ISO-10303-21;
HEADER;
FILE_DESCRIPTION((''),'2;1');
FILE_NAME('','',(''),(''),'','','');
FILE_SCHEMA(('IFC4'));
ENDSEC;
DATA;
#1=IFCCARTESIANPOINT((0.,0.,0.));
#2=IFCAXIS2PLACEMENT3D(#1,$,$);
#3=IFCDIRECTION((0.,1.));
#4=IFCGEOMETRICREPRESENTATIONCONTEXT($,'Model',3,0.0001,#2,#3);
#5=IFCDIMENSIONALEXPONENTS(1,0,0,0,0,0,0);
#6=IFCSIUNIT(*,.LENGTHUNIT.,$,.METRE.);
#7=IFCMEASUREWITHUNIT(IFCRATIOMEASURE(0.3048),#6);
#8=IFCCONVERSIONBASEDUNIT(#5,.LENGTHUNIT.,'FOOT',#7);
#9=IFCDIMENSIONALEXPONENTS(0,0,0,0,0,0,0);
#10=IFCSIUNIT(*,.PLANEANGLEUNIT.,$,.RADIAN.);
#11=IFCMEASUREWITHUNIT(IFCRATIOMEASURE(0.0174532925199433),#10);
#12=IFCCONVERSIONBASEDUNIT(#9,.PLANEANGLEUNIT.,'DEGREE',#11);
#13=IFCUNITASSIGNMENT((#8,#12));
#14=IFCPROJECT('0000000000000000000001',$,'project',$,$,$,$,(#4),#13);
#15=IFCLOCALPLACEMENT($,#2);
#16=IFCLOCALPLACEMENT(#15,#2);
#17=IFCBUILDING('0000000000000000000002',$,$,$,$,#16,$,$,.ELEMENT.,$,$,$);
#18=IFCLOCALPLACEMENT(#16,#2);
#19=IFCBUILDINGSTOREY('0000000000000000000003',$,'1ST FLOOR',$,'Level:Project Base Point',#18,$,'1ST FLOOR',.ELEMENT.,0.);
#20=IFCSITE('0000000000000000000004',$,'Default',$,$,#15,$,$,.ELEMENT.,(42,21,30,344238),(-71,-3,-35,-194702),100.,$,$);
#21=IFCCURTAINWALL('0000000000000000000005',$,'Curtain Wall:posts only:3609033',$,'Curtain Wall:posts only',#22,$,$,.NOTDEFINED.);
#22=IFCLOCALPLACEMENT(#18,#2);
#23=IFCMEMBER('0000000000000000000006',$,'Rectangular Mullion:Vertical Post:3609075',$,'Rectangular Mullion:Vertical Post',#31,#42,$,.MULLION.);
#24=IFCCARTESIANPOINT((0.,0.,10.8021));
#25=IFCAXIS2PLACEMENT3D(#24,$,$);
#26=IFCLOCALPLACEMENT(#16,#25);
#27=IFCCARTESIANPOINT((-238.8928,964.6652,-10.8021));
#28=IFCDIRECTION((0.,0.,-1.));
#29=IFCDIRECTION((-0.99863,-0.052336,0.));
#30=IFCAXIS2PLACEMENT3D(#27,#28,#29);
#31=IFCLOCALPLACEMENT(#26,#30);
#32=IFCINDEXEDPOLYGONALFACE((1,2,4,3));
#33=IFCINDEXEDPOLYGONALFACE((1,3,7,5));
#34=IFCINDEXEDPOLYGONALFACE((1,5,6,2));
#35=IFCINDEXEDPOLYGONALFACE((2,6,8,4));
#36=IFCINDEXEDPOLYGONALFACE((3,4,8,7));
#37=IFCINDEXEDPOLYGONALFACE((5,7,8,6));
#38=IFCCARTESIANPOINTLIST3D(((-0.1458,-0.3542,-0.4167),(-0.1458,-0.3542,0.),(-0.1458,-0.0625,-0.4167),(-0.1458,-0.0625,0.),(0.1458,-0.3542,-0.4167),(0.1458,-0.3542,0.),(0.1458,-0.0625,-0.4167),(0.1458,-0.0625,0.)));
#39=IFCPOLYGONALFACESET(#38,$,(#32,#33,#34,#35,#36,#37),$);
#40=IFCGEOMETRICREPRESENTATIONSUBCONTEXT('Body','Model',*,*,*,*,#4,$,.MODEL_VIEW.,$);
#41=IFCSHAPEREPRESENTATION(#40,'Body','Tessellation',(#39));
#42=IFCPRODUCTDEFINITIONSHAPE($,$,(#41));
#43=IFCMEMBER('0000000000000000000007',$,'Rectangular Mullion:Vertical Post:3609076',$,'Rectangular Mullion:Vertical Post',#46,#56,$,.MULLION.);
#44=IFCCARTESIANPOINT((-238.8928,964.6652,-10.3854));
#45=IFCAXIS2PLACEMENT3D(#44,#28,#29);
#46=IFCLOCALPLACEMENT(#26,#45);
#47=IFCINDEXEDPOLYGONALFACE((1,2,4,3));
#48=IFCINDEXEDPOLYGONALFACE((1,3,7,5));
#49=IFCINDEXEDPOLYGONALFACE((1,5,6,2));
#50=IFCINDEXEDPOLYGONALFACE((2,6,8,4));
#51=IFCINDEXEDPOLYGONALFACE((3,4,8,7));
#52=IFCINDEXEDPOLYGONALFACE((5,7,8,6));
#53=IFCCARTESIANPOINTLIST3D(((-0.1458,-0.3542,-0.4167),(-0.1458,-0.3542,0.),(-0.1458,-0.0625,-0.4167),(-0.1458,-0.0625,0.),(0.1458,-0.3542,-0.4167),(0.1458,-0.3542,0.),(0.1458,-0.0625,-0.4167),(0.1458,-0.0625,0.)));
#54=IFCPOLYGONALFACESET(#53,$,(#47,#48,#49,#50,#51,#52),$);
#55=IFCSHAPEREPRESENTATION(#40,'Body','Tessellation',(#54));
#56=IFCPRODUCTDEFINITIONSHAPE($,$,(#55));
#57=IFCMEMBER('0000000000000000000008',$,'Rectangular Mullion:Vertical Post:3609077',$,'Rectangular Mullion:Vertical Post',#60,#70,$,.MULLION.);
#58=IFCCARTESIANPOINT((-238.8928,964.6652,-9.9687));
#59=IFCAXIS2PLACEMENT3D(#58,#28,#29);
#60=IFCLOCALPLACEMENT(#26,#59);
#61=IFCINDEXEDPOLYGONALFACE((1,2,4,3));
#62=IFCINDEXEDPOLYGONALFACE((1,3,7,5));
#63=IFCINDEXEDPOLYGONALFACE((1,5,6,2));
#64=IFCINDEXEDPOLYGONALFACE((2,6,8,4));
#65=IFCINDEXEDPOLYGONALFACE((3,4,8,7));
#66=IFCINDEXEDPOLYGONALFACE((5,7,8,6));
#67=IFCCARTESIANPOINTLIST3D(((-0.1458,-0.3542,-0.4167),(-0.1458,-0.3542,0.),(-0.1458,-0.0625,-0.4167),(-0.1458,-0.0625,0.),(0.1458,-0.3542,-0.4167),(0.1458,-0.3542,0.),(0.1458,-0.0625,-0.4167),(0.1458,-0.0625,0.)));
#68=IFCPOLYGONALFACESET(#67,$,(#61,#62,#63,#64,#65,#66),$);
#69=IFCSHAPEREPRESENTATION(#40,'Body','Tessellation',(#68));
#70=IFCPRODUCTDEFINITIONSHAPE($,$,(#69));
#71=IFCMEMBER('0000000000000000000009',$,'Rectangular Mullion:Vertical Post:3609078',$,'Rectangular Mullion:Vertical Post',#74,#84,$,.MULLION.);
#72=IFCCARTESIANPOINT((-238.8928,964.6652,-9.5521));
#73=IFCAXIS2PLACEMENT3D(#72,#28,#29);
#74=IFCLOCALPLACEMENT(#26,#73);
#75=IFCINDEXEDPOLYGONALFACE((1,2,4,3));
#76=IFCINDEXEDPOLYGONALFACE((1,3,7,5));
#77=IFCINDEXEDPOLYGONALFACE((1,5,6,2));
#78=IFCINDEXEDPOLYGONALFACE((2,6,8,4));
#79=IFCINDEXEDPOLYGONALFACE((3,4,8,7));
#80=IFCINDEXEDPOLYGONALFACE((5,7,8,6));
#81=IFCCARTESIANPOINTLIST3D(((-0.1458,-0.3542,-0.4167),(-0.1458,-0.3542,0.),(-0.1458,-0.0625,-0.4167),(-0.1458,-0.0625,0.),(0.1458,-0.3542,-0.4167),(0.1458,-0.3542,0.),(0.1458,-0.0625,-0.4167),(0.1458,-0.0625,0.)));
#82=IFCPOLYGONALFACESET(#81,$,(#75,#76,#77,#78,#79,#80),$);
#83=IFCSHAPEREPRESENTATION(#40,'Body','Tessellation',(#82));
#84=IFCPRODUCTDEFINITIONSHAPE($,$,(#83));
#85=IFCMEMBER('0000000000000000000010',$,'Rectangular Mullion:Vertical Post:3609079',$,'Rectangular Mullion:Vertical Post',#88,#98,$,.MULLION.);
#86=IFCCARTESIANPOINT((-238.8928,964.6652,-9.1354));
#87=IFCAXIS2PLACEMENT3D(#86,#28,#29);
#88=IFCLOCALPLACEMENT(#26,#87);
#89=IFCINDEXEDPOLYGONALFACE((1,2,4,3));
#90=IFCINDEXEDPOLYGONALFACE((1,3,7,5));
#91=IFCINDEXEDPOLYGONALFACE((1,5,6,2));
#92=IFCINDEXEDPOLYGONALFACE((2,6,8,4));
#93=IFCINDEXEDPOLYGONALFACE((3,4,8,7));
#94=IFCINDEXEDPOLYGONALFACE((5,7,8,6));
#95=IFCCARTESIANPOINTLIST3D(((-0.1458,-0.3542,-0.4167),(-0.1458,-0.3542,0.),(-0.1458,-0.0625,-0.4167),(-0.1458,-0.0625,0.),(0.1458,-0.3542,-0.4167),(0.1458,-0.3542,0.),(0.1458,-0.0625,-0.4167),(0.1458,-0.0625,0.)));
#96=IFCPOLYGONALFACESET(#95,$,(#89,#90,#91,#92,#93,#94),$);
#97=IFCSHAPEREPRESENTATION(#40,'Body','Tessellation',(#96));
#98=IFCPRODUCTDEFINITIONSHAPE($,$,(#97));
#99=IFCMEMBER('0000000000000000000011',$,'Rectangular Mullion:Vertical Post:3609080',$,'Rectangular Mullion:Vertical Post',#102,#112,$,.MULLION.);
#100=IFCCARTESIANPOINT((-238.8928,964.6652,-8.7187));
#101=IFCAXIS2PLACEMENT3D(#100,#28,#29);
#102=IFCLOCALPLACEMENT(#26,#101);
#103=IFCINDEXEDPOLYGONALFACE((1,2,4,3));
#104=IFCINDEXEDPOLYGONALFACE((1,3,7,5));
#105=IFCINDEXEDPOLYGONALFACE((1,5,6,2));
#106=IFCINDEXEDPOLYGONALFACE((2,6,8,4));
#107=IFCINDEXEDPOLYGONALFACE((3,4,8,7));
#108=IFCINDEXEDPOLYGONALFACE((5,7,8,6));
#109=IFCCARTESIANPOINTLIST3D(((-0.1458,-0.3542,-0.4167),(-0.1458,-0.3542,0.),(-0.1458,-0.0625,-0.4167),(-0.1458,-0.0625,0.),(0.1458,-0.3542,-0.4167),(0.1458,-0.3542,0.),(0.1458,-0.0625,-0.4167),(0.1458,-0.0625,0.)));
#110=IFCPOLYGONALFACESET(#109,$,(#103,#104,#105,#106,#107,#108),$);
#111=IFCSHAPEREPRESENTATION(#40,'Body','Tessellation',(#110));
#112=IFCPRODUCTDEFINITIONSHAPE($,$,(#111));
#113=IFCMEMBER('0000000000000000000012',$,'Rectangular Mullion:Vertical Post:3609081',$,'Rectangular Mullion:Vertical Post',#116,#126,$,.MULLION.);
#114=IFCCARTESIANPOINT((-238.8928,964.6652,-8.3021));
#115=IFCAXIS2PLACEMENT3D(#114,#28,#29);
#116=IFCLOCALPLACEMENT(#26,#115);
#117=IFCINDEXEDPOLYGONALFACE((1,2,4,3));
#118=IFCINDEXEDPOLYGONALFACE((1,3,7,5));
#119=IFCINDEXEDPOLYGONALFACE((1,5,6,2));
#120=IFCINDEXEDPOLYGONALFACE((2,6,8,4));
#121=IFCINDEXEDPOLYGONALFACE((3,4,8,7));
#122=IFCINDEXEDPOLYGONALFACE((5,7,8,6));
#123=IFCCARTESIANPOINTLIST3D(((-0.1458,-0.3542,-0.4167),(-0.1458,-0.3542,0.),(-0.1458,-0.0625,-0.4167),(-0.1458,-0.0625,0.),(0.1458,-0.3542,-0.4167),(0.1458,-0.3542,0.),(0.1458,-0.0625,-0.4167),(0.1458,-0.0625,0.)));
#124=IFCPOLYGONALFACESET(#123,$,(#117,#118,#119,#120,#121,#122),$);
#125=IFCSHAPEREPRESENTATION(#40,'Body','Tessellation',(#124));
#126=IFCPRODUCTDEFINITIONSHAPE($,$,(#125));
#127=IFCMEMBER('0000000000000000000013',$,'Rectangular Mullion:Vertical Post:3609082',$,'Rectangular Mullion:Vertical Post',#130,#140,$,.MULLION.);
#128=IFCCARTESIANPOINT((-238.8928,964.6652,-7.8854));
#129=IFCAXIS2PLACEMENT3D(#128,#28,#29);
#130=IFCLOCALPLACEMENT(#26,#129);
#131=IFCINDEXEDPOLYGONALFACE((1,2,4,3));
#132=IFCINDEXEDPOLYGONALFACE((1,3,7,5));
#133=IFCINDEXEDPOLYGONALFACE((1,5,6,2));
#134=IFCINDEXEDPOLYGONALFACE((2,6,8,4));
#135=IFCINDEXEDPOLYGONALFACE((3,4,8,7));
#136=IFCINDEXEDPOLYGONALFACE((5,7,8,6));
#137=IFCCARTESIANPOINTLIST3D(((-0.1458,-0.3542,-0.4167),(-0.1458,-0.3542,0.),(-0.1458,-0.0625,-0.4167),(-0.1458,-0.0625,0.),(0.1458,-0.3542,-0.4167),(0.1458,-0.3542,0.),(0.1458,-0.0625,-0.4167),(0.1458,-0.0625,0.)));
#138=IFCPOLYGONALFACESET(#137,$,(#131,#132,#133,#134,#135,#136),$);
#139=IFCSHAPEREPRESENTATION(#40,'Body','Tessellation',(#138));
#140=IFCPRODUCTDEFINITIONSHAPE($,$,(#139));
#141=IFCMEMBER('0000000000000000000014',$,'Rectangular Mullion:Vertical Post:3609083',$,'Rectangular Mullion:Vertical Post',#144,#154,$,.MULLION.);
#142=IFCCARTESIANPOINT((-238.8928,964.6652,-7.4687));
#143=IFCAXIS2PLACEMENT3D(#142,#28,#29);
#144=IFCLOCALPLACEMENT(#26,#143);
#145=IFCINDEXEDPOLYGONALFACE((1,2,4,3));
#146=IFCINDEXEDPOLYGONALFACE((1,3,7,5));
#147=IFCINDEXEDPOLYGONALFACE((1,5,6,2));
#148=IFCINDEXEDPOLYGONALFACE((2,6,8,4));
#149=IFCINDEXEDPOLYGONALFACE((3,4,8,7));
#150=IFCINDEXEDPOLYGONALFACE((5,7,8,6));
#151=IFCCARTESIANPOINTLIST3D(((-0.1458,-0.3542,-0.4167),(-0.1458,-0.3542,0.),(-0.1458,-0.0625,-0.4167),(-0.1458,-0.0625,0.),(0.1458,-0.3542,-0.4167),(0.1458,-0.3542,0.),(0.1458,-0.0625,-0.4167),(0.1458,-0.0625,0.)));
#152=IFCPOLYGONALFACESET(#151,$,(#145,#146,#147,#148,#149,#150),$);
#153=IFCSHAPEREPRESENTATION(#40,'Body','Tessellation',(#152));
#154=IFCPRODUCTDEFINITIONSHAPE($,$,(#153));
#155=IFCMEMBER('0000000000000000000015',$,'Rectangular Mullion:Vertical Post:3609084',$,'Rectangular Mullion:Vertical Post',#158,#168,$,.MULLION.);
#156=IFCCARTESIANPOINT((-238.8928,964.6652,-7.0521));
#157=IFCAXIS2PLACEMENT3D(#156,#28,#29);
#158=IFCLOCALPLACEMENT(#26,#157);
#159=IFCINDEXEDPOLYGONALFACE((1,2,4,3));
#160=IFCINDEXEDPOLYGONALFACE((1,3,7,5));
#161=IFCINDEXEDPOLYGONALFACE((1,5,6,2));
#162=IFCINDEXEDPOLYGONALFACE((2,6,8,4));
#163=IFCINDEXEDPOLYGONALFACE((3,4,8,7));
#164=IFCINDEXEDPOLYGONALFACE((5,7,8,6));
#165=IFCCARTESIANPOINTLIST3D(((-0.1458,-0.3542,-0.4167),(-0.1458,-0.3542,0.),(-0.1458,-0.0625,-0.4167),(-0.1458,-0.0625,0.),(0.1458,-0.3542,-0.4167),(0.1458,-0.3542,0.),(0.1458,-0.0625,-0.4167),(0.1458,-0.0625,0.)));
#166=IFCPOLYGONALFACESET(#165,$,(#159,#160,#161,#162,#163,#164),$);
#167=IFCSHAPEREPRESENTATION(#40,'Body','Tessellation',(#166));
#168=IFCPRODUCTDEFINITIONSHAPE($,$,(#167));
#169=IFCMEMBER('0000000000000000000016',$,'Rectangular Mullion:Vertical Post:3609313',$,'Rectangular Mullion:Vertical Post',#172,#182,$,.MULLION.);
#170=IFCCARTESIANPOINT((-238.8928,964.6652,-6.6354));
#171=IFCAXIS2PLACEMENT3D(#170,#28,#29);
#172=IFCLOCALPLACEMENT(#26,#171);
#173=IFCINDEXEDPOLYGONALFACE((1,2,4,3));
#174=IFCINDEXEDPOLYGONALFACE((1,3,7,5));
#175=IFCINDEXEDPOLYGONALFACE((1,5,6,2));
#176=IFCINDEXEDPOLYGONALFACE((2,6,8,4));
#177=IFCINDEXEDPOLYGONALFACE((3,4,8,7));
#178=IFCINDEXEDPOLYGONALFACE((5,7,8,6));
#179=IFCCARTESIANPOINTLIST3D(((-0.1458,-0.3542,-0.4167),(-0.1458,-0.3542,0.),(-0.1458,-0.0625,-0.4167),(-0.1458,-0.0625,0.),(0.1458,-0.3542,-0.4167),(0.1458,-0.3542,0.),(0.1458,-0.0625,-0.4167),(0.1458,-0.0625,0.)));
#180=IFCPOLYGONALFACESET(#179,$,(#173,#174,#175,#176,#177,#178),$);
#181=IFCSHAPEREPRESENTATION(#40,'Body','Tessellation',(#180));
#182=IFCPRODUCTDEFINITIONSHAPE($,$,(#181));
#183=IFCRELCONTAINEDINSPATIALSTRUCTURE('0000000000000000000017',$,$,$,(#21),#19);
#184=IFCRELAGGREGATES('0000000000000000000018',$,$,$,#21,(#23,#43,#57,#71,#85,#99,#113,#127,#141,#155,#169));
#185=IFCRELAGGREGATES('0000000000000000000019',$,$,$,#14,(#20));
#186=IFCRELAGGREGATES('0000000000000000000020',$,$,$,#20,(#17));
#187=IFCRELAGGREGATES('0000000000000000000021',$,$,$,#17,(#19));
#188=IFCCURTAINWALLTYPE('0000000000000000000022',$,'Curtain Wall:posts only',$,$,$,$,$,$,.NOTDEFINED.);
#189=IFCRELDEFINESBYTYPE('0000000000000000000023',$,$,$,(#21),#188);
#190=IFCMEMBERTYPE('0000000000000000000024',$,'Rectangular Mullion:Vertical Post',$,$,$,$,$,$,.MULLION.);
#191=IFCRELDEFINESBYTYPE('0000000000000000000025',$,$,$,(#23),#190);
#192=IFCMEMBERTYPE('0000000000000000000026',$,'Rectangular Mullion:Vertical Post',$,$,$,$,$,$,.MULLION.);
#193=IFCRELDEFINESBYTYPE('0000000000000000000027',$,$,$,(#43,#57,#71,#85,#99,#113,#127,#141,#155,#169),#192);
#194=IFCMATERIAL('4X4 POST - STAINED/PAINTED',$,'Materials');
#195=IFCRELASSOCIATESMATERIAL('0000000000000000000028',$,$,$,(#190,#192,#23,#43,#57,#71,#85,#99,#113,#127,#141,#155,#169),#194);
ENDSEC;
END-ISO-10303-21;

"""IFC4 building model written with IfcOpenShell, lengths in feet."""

from ifc_helpers import new_model, entity, si_unit, converted_unit, direction, frame, origin, origin_2d_with_axis, place, context, subcontext, project, spatial, rectangle, extrude, source, transform, mapped, material, material_profile, profile_set, profile_usage, type_object, type_shapes, element, aggregate, save


model = new_model("IFC4")

# Units and contexts
model_context = context("Model", 3, precision=0.0001, world=origin(), true_north=direction((0.0, 1.0)))
body_context = subcontext(model_context, "Body", "Model", "MODEL_VIEW")
ifc_project = project(units=[converted_unit("LENGTHUNIT", "FOOT", entity("IfcRatioMeasure", 0.3048), si_unit("LENGTHUNIT", "METRE"), dimensions=[1, 0, 0, 0, 0, 0, 0]), converted_unit("PLANEANGLEUNIT", "DEGREE", entity("IfcRatioMeasure", 0.0174532925199433), si_unit("PLANEANGLEUNIT", "RADIAN"), dimensions=[0, 0, 0, 0, 0, 0, 0])], contexts=[model_context])

# Site, building, storey
site_placement = place(None, origin())
site = spatial("IfcSite", under=ifc_project, at=site_placement, Name="Default", CompositionType="ELEMENT", RefLatitude=(42, 21, 30, 344238), RefLongitude=(-71, -3, -35, -194702), RefElevation=100.0)
building_placement = place(site_placement, origin())
building = spatial("IfcBuilding", under=site, at=building_placement, CompositionType="ELEMENT")
storey_placement = place(building_placement, origin())
storey = spatial("IfcBuildingStorey", under=building, at=storey_placement, Name="1ST FLOOR", ObjectType="Level:Project Base Point", LongName="1ST FLOOR", CompositionType="ELEMENT", Elevation=0.0)

# Curtain wall, members
curtain_wall_type_1 = type_object("IfcCurtainWallType", Name="Curtain Wall:posts only", PredefinedType="NOTDEFINED")
curtain_wall_1_placement = place(storey_placement, origin())
curtain_wall_1 = element("IfcCurtainWall", 1, at=curtain_wall_1_placement, inside=storey, type_object=curtain_wall_type_1, Name="Curtain Wall:posts only:3609033", ObjectType="Curtain Wall:posts only", PredefinedType="NOTDEFINED")
ifc_material_1 = material(Name="4X4 POST - STAINED/PAINTED", Category="Materials")
ifc_material_profile_1 = material_profile(ifc_material_1, rectangle(XDim=0.2917, YDim=0.2917, at=origin_2d_with_axis()), Name="Vertical Post")
ifc_profile_set_1 = profile_set([ifc_material_profile_1], Name="Vertical Post")
ifc_profile_usage_1 = profile_usage(ifc_profile_set_1)
member_type_1 = type_object("IfcMemberType", Name="Rectangular Mullion:Vertical Post", PredefinedType="MULLION", material=ifc_profile_set_1)
shared_shape_1 = source(origin(), body_context, "Body", "SweptSolid", [
    extrude(rectangle(XDim=0.2917, YDim=0.2917, at=origin_2d_with_axis()), frame((0.0, -0.2083, -0.4167), z_axis=(0.0, 0.0, 1.0), x_axis=(0.0, -1.0, 0.0)), (0.0, 0.0, 1.0), 0.4167),
])
type_shapes(member_type_1, [shared_shape_1])
placement = place(building_placement, frame((0.0, 0.0, 10.8021)))
member_1_placement = place(placement, frame((-238.8928, 964.6652, -10.8021), z_axis=(0.0, 0.0, -1.0), x_axis=(-0.99863, -0.052336, 0.0)))
member_1 = element("IfcMember", 2, at=member_1_placement, type_object=member_type_1, material=ifc_profile_usage_1, Name="Rectangular Mullion:Vertical Post:3609075", ObjectType="Rectangular Mullion:Vertical Post", PredefinedType="MULLION", context=body_context, shape_type="MappedRepresentation", body=[
    mapped(shared_shape_1, transform((0.0, 0.0, 0.0), scale=1.0)),
])
ifc_profile_usage_2 = profile_usage(ifc_profile_set_1)
member_type_2 = type_object("IfcMemberType", Name="Rectangular Mullion:Vertical Post", PredefinedType="MULLION", material=ifc_profile_set_1)
shared_shape_2 = source(origin(), body_context, "Body", "SweptSolid", [
    extrude(rectangle(XDim=0.2917, YDim=0.2917, at=origin_2d_with_axis()), frame((0.0, -0.2083, -0.4167), z_axis=(0.0, 0.0, 1.0), x_axis=(0.0, -1.0, 0.0)), (0.0, 0.0, 1.0), 0.4167),
])
type_shapes(member_type_2, [shared_shape_2])
member_2_placement = place(placement, frame((-238.8928, 964.6652, -10.3854), z_axis=(0.0, 0.0, -1.0), x_axis=(-0.99863, -0.052336, 0.0)))
member_2 = element("IfcMember", 3, at=member_2_placement, type_object=member_type_2, material=ifc_profile_usage_2, Name="Rectangular Mullion:Vertical Post:3609076", ObjectType="Rectangular Mullion:Vertical Post", PredefinedType="MULLION", context=body_context, shape_type="MappedRepresentation", body=[
    mapped(shared_shape_2, transform((0.0, 0.0, 0.0), scale=1.0)),
])
ifc_profile_usage_3 = profile_usage(ifc_profile_set_1)
member_3_placement = place(placement, frame((-238.8928, 964.6652, -9.9687), z_axis=(0.0, 0.0, -1.0), x_axis=(-0.99863, -0.052336, 0.0)))
member_3 = element("IfcMember", 4, at=member_3_placement, type_object=member_type_2, material=ifc_profile_usage_3, Name="Rectangular Mullion:Vertical Post:3609077", ObjectType="Rectangular Mullion:Vertical Post", PredefinedType="MULLION", context=body_context, shape_type="MappedRepresentation", body=[
    mapped(shared_shape_2, transform((0.0, 0.0, 0.0), scale=1.0)),
])
ifc_profile_usage_4 = profile_usage(ifc_profile_set_1)
member_4_placement = place(placement, frame((-238.8928, 964.6652, -9.5521), z_axis=(0.0, 0.0, -1.0), x_axis=(-0.99863, -0.052336, 0.0)))
member_4 = element("IfcMember", 5, at=member_4_placement, type_object=member_type_2, material=ifc_profile_usage_4, Name="Rectangular Mullion:Vertical Post:3609078", ObjectType="Rectangular Mullion:Vertical Post", PredefinedType="MULLION", context=body_context, shape_type="MappedRepresentation", body=[
    mapped(shared_shape_2, transform((0.0, 0.0, 0.0), scale=1.0)),
])
ifc_profile_usage_5 = profile_usage(ifc_profile_set_1)
member_5_placement = place(placement, frame((-238.8928, 964.6652, -9.1354), z_axis=(0.0, 0.0, -1.0), x_axis=(-0.99863, -0.052336, 0.0)))
member_5 = element("IfcMember", 6, at=member_5_placement, type_object=member_type_2, material=ifc_profile_usage_5, Name="Rectangular Mullion:Vertical Post:3609079", ObjectType="Rectangular Mullion:Vertical Post", PredefinedType="MULLION", context=body_context, shape_type="MappedRepresentation", body=[
    mapped(shared_shape_2, transform((0.0, 0.0, 0.0), scale=1.0)),
])
ifc_profile_usage_6 = profile_usage(ifc_profile_set_1)
member_6_placement = place(placement, frame((-238.8928, 964.6652, -8.7187), z_axis=(0.0, 0.0, -1.0), x_axis=(-0.99863, -0.052336, 0.0)))
member_6 = element("IfcMember", 7, at=member_6_placement, type_object=member_type_2, material=ifc_profile_usage_6, Name="Rectangular Mullion:Vertical Post:3609080", ObjectType="Rectangular Mullion:Vertical Post", PredefinedType="MULLION", context=body_context, shape_type="MappedRepresentation", body=[
    mapped(shared_shape_2, transform((0.0, 0.0, 0.0), scale=1.0)),
])
ifc_profile_usage_7 = profile_usage(ifc_profile_set_1)
member_7_placement = place(placement, frame((-238.8928, 964.6652, -8.3021), z_axis=(0.0, 0.0, -1.0), x_axis=(-0.99863, -0.052336, 0.0)))
member_7 = element("IfcMember", 8, at=member_7_placement, type_object=member_type_2, material=ifc_profile_usage_7, Name="Rectangular Mullion:Vertical Post:3609081", ObjectType="Rectangular Mullion:Vertical Post", PredefinedType="MULLION", context=body_context, shape_type="MappedRepresentation", body=[
    mapped(shared_shape_2, transform((0.0, 0.0, 0.0), scale=1.0)),
])
ifc_profile_usage_8 = profile_usage(ifc_profile_set_1)
member_8_placement = place(placement, frame((-238.8928, 964.6652, -7.8854), z_axis=(0.0, 0.0, -1.0), x_axis=(-0.99863, -0.052336, 0.0)))
member_8 = element("IfcMember", 9, at=member_8_placement, type_object=member_type_2, material=ifc_profile_usage_8, Name="Rectangular Mullion:Vertical Post:3609082", ObjectType="Rectangular Mullion:Vertical Post", PredefinedType="MULLION", context=body_context, shape_type="MappedRepresentation", body=[
    mapped(shared_shape_2, transform((0.0, 0.0, 0.0), scale=1.0)),
])
ifc_profile_usage_9 = profile_usage(ifc_profile_set_1)
member_9_placement = place(placement, frame((-238.8928, 964.6652, -7.4687), z_axis=(0.0, 0.0, -1.0), x_axis=(-0.99863, -0.052336, 0.0)))
member_9 = element("IfcMember", 10, at=member_9_placement, type_object=member_type_2, material=ifc_profile_usage_9, Name="Rectangular Mullion:Vertical Post:3609083", ObjectType="Rectangular Mullion:Vertical Post", PredefinedType="MULLION", context=body_context, shape_type="MappedRepresentation", body=[
    mapped(shared_shape_2, transform((0.0, 0.0, 0.0), scale=1.0)),
])
ifc_profile_usage_10 = profile_usage(ifc_profile_set_1)
member_10_placement = place(placement, frame((-238.8928, 964.6652, -7.0521), z_axis=(0.0, 0.0, -1.0), x_axis=(-0.99863, -0.052336, 0.0)))
member_10 = element("IfcMember", 11, at=member_10_placement, type_object=member_type_2, material=ifc_profile_usage_10, Name="Rectangular Mullion:Vertical Post:3609084", ObjectType="Rectangular Mullion:Vertical Post", PredefinedType="MULLION", context=body_context, shape_type="MappedRepresentation", body=[
    mapped(shared_shape_2, transform((0.0, 0.0, 0.0), scale=1.0)),
])
ifc_profile_usage_11 = profile_usage(ifc_profile_set_1)
member_11_placement = place(placement, frame((-238.8928, 964.6652, -6.6354), z_axis=(0.0, 0.0, -1.0), x_axis=(-0.99863, -0.052336, 0.0)))
member_11 = element("IfcMember", 12, at=member_11_placement, type_object=member_type_2, material=ifc_profile_usage_11, Name="Rectangular Mullion:Vertical Post:3609313", ObjectType="Rectangular Mullion:Vertical Post", PredefinedType="MULLION", context=body_context, shape_type="MappedRepresentation", body=[
    mapped(shared_shape_2, transform((0.0, 0.0, 0.0), scale=1.0)),
])
aggregate(curtain_wall_1, [member_1, member_2, member_3, member_4, member_5, member_6, member_7, member_8, member_9, member_10, member_11])

save(model, "model.ifc")
